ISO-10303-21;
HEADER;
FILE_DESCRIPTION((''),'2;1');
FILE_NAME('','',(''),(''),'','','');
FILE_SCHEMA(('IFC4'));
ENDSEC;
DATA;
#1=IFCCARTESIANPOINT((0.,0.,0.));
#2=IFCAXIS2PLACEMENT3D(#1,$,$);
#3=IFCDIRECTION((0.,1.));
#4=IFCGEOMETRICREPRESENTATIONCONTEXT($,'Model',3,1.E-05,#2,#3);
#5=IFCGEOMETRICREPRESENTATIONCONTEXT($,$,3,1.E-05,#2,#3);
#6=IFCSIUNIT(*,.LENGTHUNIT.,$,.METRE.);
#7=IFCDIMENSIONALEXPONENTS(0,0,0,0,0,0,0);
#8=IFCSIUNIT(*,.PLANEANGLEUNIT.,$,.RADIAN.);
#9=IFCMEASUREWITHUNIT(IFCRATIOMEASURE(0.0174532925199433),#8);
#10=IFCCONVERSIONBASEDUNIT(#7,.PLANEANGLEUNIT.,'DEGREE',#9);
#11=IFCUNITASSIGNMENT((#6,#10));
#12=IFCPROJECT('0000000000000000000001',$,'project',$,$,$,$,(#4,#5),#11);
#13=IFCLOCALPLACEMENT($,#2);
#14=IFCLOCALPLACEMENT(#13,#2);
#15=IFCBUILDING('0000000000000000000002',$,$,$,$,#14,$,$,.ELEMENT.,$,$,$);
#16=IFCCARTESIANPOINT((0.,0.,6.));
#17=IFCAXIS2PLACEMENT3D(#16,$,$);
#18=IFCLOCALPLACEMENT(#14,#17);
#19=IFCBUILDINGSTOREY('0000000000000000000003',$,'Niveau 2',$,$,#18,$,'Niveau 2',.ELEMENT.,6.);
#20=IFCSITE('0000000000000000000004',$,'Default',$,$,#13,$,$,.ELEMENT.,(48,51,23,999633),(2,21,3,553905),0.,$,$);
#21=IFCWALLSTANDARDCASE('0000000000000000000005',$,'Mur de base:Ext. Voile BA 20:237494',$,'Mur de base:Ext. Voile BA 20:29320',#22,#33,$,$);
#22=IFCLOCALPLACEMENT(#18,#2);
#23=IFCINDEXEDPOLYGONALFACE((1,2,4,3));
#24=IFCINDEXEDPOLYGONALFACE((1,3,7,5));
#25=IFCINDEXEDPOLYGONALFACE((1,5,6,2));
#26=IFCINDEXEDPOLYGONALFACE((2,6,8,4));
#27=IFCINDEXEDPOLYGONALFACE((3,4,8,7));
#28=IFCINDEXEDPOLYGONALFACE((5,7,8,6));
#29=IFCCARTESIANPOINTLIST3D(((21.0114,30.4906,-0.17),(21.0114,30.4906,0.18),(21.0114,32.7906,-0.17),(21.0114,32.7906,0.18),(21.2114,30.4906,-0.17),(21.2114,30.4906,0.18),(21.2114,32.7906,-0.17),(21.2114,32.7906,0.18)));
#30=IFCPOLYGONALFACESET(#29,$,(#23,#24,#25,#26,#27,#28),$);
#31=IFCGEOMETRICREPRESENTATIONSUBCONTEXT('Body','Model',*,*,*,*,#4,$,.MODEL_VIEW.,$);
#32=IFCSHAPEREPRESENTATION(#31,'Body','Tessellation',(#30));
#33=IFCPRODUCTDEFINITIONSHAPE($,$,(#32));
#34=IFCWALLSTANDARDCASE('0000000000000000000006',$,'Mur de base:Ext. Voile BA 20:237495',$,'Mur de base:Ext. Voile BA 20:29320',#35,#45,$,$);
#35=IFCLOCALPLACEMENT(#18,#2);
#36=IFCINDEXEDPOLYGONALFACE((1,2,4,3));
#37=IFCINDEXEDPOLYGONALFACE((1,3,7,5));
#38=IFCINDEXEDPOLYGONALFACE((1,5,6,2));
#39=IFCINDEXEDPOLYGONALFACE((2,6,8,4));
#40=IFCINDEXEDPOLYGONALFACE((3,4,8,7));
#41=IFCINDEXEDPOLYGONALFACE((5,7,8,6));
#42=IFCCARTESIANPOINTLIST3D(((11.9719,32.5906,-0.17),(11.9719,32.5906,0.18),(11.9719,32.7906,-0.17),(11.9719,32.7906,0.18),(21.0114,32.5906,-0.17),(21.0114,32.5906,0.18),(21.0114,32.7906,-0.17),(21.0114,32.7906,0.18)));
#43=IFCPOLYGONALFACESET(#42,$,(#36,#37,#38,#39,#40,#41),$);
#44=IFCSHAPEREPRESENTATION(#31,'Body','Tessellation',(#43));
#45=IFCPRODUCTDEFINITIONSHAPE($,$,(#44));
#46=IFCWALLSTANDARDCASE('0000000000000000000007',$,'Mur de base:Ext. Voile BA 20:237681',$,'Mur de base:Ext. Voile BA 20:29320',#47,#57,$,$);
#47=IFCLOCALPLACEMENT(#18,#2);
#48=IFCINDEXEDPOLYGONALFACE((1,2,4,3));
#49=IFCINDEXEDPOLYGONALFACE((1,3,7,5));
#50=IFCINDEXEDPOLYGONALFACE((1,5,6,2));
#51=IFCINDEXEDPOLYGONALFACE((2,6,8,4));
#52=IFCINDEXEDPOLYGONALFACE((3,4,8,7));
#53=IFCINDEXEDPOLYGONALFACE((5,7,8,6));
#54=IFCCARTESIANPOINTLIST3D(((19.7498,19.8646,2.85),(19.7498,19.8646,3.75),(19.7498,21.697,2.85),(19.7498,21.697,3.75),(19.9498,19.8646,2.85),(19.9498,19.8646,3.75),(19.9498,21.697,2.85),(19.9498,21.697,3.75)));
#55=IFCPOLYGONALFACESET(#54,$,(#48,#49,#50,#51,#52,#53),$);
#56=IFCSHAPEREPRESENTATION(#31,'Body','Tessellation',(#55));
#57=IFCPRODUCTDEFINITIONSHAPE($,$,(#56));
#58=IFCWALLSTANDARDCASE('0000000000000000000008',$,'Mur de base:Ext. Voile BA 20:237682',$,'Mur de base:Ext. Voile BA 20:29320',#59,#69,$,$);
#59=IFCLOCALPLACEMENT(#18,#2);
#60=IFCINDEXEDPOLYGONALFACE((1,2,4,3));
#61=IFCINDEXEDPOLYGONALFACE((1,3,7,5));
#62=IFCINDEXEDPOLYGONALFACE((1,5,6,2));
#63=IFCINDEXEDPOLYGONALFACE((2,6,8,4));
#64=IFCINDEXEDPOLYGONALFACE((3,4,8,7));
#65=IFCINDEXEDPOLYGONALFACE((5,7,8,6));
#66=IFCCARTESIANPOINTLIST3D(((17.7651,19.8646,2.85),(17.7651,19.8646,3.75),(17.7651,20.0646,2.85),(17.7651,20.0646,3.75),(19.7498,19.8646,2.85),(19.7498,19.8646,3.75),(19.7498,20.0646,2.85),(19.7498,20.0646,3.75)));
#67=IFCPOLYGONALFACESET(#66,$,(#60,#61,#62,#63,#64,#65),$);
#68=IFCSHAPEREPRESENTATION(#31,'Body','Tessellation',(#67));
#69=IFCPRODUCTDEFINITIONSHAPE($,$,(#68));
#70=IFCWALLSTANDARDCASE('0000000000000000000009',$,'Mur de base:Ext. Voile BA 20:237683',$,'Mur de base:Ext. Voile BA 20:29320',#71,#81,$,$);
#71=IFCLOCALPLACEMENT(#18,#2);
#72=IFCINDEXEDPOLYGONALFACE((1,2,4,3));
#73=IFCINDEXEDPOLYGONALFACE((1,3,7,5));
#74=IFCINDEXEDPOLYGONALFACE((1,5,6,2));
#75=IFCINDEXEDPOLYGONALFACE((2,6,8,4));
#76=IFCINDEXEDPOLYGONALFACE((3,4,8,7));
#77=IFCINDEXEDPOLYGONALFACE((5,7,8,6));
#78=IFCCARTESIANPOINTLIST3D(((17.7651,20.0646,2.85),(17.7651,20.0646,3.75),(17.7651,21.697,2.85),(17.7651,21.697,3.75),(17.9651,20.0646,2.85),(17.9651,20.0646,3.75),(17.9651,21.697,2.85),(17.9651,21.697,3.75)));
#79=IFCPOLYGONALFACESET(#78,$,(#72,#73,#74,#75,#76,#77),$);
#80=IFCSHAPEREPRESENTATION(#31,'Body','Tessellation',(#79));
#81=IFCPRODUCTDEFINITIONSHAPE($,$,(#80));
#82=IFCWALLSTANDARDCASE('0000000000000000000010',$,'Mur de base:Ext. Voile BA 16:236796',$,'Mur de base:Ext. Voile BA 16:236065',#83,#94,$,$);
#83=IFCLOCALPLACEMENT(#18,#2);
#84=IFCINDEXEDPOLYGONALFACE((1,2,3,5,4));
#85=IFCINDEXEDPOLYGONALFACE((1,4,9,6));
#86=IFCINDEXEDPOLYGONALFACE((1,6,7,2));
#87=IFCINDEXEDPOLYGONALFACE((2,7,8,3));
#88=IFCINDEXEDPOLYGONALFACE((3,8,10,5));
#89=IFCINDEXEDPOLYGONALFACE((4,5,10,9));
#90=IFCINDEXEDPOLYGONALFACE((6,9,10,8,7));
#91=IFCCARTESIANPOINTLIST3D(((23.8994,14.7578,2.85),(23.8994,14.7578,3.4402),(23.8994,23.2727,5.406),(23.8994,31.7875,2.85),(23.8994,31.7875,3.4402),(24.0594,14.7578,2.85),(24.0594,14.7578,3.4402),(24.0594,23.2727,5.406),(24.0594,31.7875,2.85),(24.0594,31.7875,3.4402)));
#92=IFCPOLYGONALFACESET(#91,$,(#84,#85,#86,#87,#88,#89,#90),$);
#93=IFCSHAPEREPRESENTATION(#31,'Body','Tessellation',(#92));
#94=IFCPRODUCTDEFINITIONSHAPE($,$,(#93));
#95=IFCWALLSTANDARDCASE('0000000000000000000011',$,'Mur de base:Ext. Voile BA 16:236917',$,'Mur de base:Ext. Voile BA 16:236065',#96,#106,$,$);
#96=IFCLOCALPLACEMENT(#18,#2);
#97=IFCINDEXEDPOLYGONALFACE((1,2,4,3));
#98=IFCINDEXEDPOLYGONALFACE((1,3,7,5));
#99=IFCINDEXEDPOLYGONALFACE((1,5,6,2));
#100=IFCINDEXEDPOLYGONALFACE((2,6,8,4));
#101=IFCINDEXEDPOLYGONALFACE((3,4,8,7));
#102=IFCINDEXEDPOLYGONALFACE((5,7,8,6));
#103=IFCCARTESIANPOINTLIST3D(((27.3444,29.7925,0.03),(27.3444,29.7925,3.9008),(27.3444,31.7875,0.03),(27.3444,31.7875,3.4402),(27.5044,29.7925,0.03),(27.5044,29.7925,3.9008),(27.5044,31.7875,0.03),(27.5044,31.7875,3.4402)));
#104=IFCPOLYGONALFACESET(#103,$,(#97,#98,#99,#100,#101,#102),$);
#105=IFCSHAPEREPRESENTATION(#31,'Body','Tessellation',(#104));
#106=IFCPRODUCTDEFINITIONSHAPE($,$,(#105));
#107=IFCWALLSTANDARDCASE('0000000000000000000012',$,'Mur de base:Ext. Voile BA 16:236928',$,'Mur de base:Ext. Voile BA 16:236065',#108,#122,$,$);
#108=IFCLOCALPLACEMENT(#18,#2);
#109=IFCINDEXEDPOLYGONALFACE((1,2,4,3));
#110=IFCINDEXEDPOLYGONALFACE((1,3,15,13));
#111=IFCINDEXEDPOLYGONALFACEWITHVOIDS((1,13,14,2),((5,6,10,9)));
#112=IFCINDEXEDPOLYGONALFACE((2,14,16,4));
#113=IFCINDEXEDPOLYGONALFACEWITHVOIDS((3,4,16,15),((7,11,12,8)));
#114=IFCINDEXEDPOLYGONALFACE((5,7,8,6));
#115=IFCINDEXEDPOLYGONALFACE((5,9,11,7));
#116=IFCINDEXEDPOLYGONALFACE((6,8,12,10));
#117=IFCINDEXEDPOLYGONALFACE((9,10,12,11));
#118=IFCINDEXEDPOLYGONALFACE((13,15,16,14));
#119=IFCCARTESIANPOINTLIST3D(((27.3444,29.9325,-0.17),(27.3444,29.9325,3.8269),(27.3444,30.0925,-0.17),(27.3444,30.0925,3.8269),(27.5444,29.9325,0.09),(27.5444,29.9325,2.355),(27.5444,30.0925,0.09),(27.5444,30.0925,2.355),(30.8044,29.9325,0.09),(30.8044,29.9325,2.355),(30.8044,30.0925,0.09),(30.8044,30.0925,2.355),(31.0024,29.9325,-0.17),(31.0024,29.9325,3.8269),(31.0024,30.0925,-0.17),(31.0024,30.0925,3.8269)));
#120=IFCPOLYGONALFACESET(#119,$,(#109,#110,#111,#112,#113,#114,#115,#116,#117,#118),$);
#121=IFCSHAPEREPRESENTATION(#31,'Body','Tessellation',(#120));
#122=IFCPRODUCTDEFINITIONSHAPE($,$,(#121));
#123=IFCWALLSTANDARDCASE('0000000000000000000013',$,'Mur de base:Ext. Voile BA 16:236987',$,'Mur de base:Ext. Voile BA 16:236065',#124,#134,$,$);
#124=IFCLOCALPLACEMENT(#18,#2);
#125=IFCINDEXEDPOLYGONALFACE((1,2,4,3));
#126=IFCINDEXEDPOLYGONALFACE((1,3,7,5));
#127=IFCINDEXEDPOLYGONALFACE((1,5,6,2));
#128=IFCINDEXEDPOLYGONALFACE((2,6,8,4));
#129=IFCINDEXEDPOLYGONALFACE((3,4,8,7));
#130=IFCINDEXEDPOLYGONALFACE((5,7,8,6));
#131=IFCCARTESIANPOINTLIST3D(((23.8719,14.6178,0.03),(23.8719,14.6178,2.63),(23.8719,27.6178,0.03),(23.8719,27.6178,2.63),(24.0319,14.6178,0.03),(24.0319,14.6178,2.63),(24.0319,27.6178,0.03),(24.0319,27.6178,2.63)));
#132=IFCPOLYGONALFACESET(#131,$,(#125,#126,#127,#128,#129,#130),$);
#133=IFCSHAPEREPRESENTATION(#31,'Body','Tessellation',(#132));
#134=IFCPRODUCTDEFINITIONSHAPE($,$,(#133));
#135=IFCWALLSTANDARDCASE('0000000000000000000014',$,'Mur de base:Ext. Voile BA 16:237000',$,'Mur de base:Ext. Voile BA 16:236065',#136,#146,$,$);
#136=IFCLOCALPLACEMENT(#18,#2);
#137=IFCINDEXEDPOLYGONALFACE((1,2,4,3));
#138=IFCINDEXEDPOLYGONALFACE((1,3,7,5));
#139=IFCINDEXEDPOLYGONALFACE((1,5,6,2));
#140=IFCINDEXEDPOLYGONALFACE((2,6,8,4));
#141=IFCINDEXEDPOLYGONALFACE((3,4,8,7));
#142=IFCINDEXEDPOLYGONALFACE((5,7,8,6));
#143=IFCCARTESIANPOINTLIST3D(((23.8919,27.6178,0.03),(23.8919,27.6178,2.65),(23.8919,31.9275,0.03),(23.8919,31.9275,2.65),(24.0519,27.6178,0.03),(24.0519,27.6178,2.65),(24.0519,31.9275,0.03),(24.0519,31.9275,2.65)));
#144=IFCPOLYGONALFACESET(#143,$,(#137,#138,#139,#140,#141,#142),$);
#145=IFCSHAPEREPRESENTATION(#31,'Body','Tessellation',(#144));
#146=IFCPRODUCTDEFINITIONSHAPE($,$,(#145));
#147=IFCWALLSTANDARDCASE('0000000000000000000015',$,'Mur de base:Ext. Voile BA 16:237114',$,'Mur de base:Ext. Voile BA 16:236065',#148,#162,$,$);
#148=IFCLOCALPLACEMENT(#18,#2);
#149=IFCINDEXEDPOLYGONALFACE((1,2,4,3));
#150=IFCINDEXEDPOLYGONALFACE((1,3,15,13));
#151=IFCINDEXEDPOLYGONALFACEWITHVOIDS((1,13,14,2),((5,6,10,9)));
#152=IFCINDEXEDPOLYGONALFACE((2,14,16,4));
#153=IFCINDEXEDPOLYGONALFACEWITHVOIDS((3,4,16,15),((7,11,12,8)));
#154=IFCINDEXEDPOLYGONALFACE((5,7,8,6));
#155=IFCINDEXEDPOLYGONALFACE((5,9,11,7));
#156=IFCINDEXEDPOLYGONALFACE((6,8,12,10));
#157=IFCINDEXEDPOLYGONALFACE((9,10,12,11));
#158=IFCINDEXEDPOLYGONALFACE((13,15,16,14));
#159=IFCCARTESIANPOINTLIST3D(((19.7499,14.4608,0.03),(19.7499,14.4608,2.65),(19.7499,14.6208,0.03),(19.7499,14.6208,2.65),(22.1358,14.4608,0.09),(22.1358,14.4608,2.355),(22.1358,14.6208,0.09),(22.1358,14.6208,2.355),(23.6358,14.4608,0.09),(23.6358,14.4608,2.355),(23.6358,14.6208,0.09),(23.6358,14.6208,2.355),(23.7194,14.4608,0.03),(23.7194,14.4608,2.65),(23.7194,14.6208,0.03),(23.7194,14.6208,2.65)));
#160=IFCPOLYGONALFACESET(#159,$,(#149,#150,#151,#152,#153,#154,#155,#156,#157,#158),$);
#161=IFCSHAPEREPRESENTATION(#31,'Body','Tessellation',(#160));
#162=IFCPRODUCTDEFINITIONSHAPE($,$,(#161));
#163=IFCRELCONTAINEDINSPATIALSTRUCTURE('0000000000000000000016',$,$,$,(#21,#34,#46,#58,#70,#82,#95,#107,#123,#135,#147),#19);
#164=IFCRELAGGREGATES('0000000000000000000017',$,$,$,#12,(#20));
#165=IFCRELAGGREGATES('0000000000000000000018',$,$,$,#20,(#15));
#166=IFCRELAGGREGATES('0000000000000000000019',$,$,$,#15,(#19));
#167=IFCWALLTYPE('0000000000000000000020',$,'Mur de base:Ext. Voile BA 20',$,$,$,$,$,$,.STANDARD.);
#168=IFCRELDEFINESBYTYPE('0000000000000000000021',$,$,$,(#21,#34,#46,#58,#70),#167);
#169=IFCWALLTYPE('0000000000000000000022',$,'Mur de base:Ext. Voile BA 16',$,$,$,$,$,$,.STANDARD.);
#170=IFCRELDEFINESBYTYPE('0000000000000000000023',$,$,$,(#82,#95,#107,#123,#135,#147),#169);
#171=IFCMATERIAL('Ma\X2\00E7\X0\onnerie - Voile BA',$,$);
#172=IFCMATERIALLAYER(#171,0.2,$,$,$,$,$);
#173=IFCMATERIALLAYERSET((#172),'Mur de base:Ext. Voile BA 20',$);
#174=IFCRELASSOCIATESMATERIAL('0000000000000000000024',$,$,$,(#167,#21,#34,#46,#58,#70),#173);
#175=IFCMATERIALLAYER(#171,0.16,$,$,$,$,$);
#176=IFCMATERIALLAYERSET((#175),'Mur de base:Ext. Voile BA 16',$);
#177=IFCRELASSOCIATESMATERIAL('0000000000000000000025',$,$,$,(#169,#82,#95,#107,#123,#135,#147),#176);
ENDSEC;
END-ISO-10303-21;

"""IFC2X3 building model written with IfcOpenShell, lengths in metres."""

from ifc_helpers import new_model, entity, si_unit, converted_unit, direction, frame, frame_2d, origin, origin_2d_with_axis, place, context, subcontext, project, spatial, rectangle, extrude, clip, halfspace, material, layer, layer_set, layer_usage, type_object, element, save


model = new_model("IFC2X3")

# Units and contexts
model_context = context("Model", 3, precision=1e-05, world=origin(), true_north=direction((0.0, 1.0)))
context_of_model = context(None, 3, precision=1e-05, world=origin(), true_north=direction((0.0, 1.0)))
body_context = subcontext(model_context, "Body", "Model", "MODEL_VIEW")
ifc_project = project(units=[si_unit("LENGTHUNIT", "METRE"), converted_unit("PLANEANGLEUNIT", "DEGREE", entity("IfcRatioMeasure", 0.0174532925199433), si_unit("PLANEANGLEUNIT", "RADIAN"), dimensions=[0, 0, 0, 0, 0, 0, 0])], contexts=[model_context, context_of_model])

# Site, building, storey
site_placement = place(None, origin())
site = spatial("IfcSite", under=ifc_project, at=site_placement, Name="Default", CompositionType="ELEMENT", RefLatitude=(48, 51, 23, 999633), RefLongitude=(2, 21, 3, 553905), RefElevation=0.0)
building_placement = place(site_placement, origin())
building = spatial("IfcBuilding", under=site, at=building_placement, CompositionType="ELEMENT")
storey_placement = place(building_placement, frame((0.0, 0.0, 6.0)))
storey = spatial("IfcBuildingStorey", under=building, at=storey_placement, Name="Niveau 2", LongName="Niveau 2", CompositionType="ELEMENT", Elevation=6.0)

# Shared definitions
ifc_material = material(Name="Maçonnerie - Voile BA")
ifc_layer_1 = layer(ifc_material, 0.2)
ifc_layer_set_1 = layer_set([ifc_layer_1], Name="Mur de base:Ext. Voile BA 20")
wall_type_1 = type_object("IfcWallType", Name="Mur de base:Ext. Voile BA 20", PredefinedType="STANDARD", material=ifc_layer_set_1)

# Walls
ifc_layer_usage_1 = layer_usage(ifc_layer_set_1, "AXIS2", "POSITIVE", -0.1)
wall_1_placement = place(storey_placement, frame((21.1114, 30.4906, -0.17), z_axis=(0.0, 0.0, 1.0), x_axis=(0.0, 1.0, 0.0)))
element("IfcWallStandardCase", 1, at=wall_1_placement, inside=storey, type_object=wall_type_1, material=ifc_layer_usage_1, Name="Mur de base:Ext. Voile BA 20:237494", ObjectType="Mur de base:Ext. Voile BA 20:29320", context=body_context, shape_type="SweptSolid", body=[
    extrude(rectangle(XDim=2.3, YDim=0.2, at=frame_2d((1.15, 0.0), x_axis=(-1.0, 0.0))), origin(), (0.0, 0.0, 1.0), 0.35),
])
ifc_layer_usage_2 = layer_usage(ifc_layer_set_1, "AXIS2", "POSITIVE", -0.1)
wall_2_placement = place(storey_placement, frame((21.0114, 32.6906, -0.17), z_axis=(0.0, 0.0, 1.0), x_axis=(-1.0, 0.0, 0.0)))
element("IfcWallStandardCase", 2, at=wall_2_placement, inside=storey, type_object=wall_type_1, material=ifc_layer_usage_2, Name="Mur de base:Ext. Voile BA 20:237495", ObjectType="Mur de base:Ext. Voile BA 20:29320", context=body_context, shape_type="SweptSolid", body=[
    extrude(rectangle(XDim=9.0395, YDim=0.2, at=frame_2d((4.5197, 0.0), x_axis=(-1.0, 0.0))), origin(), (0.0, 0.0, 1.0), 0.35),
])
ifc_layer_usage_3 = layer_usage(ifc_layer_set_1, "AXIS2", "NEGATIVE", 0.1)
wall_3_placement = place(storey_placement, frame((19.8498, 21.697, 2.85), z_axis=(0.0, 0.0, 1.0), x_axis=(0.0, -1.0, 0.0)))
element("IfcWallStandardCase", 3, at=wall_3_placement, inside=storey, type_object=wall_type_1, material=ifc_layer_usage_3, Name="Mur de base:Ext. Voile BA 20:237681", ObjectType="Mur de base:Ext. Voile BA 20:29320", context=body_context, shape_type="SweptSolid", body=[
    extrude(rectangle(XDim=1.8324, YDim=0.2, at=frame_2d((0.9162, 0.0), x_axis=(-1.0, 0.0))), origin(), (0.0, 0.0, 1.0), 0.9),
])
ifc_layer_usage_4 = layer_usage(ifc_layer_set_1, "AXIS2", "NEGATIVE", 0.1)
wall_4_placement = place(storey_placement, frame((19.7498, 19.9646, 2.85), z_axis=(0.0, 0.0, 1.0), x_axis=(-1.0, 0.0, 0.0)))
element("IfcWallStandardCase", 4, at=wall_4_placement, inside=storey, type_object=wall_type_1, material=ifc_layer_usage_4, Name="Mur de base:Ext. Voile BA 20:237682", ObjectType="Mur de base:Ext. Voile BA 20:29320", context=body_context, shape_type="SweptSolid", body=[
    extrude(rectangle(XDim=1.9848, YDim=0.2, at=frame_2d((0.9924, 0.0), x_axis=(-1.0, 0.0))), origin(), (0.0, 0.0, 1.0), 0.9),
])
ifc_layer_usage_5 = layer_usage(ifc_layer_set_1, "AXIS2", "NEGATIVE", 0.1)
wall_5_placement = place(storey_placement, frame((17.8651, 20.0646, 2.85), z_axis=(0.0, 0.0, 1.0), x_axis=(0.0, 1.0, 0.0)))
element("IfcWallStandardCase", 5, at=wall_5_placement, inside=storey, type_object=wall_type_1, material=ifc_layer_usage_5, Name="Mur de base:Ext. Voile BA 20:237683", ObjectType="Mur de base:Ext. Voile BA 20:29320", context=body_context, shape_type="SweptSolid", body=[
    extrude(rectangle(XDim=1.6324, YDim=0.2, at=frame_2d((0.8162, 0.0), x_axis=(-1.0, 0.0))), origin(), (0.0, 0.0, 1.0), 0.9),
])
ifc_layer_2 = layer(ifc_material, 0.16)
ifc_layer_set_2 = layer_set([ifc_layer_2], Name="Mur de base:Ext. Voile BA 16")
ifc_layer_usage_6 = layer_usage(ifc_layer_set_2, "AXIS2", "NEGATIVE", 0.08)
wall_type_2 = type_object("IfcWallType", Name="Mur de base:Ext. Voile BA 16", PredefinedType="STANDARD", material=ifc_layer_set_2)
wall_6_placement = place(storey_placement, frame((23.9794, 14.7578, 2.85), z_axis=(0.0, 0.0, 1.0), x_axis=(0.0, 1.0, 0.0)))
element("IfcWallStandardCase", 6, at=wall_6_placement, inside=storey, type_object=wall_type_2, material=ifc_layer_usage_6, Name="Mur de base:Ext. Voile BA 16:236796", ObjectType="Mur de base:Ext. Voile BA 16:236065", context=body_context, shape_type="Clipping", body=[
    clip(clip(extrude(rectangle(XDim=17.0297, YDim=0.16, at=frame_2d((8.5148, 0.0), x_axis=(-1.0, 0.0))), origin(), (0.0, 0.0, 1.0), 2.556), halfspace(frame((0.0, -0.08, 0.5902), z_axis=(-0.224951, 0.0, 0.97437), x_axis=(0.0, 1.0, 0.0)), False)), halfspace(frame((8.5148, -0.08, 2.556), z_axis=(0.224951, 0.0, 0.97437), x_axis=(0.0, 1.0, 0.0)), False)),
])

# Wall
ifc_layer_usage_7 = layer_usage(ifc_layer_set_2, "AXIS2", "NEGATIVE", 0.08)
wall_7_placement = place(storey_placement, frame((27.4244, 31.7875, 0.03), z_axis=(0.0, 0.0, 1.0), x_axis=(0.0, -1.0, 0.0)))
element("IfcWallStandardCase", 7, at=wall_7_placement, inside=storey, type_object=wall_type_2, material=ifc_layer_usage_7, Name="Mur de base:Ext. Voile BA 16:236917", ObjectType="Mur de base:Ext. Voile BA 16:236065", context=body_context, shape_type="Clipping", body=[
    clip(extrude(rectangle(XDim=1.995, YDim=0.16, at=frame_2d((0.9975, 0.0), x_axis=(-1.0, 0.0))), origin(), (0.0, 0.0, 1.0), 3.8708), halfspace(frame((0.0, -0.08, 3.4102), z_axis=(-0.224951, 0.0, 0.97437), x_axis=(0.0, 1.0, 0.0)), False)),
])

# Wall, opening
ifc_layer_usage_8 = layer_usage(ifc_layer_set_2, "AXIS2", "NEGATIVE", 0.08)
wall_8_placement = place(storey_placement, frame((27.3444, 30.0125, -0.17)))
wall_8 = element("IfcWallStandardCase", 8, at=wall_8_placement, inside=storey, type_object=wall_type_2, material=ifc_layer_usage_8, Name="Mur de base:Ext. Voile BA 16:236928", ObjectType="Mur de base:Ext. Voile BA 16:236065", context=body_context, shape_type="SweptSolid", body=[
    extrude(rectangle(XDim=3.658, YDim=0.16, at=frame_2d((1.829, 0.0), x_axis=(-1.0, 0.0))), origin(), (0.0, 0.0, 1.0), 3.9969),
])
opening_1_placement = place(wall_8_placement, origin())
element("IfcOpeningElement", 9, at=opening_1_placement, cuts=wall_8, ObjectType="Opening", context=body_context, shape_type="SweptSolid", body=[
    extrude(rectangle(XDim=2.265, YDim=3.26, at=origin_2d_with_axis()), frame((1.83, -0.08, 1.3925), z_axis=(0.0, 1.0, 0.0), x_axis=(0.0, 0.0, -1.0)), (0.0, 0.0, 1.0), 0.16),
])

# Walls
ifc_layer_usage_9 = layer_usage(ifc_layer_set_2, "AXIS2", "NEGATIVE", 0.08)
wall_9_placement = place(storey_placement, frame((23.9519, 27.6178, 0.03), z_axis=(0.0, 0.0, 1.0), x_axis=(0.0, -1.0, 0.0)))
element("IfcWallStandardCase", 10, at=wall_9_placement, inside=storey, type_object=wall_type_2, material=ifc_layer_usage_9, Name="Mur de base:Ext. Voile BA 16:236987", ObjectType="Mur de base:Ext. Voile BA 16:236065", context=body_context, shape_type="SweptSolid", body=[
    extrude(rectangle(XDim=13.0, YDim=0.16, at=frame_2d((6.5, 0.0), x_axis=(-1.0, 0.0))), origin(), (0.0, 0.0, 1.0), 2.6),
])
ifc_layer_usage_10 = layer_usage(ifc_layer_set_2, "AXIS2", "NEGATIVE", 0.08)
wall_10_placement = place(storey_placement, frame((23.9719, 27.6178, 0.03), z_axis=(0.0, 0.0, 1.0), x_axis=(0.0, 1.0, 0.0)))
element("IfcWallStandardCase", 11, at=wall_10_placement, inside=storey, type_object=wall_type_2, material=ifc_layer_usage_10, Name="Mur de base:Ext. Voile BA 16:237000", ObjectType="Mur de base:Ext. Voile BA 16:236065", context=body_context, shape_type="SweptSolid", body=[
    extrude(rectangle(XDim=4.3097, YDim=0.16, at=frame_2d((2.1548, 0.0), x_axis=(-1.0, 0.0))), origin(), (0.0, 0.0, 1.0), 2.62),
])

# Wall, opening
ifc_layer_usage_11 = layer_usage(ifc_layer_set_2, "AXIS2", "NEGATIVE", 0.08)
wall_11_placement = place(storey_placement, frame((23.7194, 14.5408, 0.03), z_axis=(0.0, 0.0, 1.0), x_axis=(-1.0, 0.0, 0.0)))
wall_11 = element("IfcWallStandardCase", 12, at=wall_11_placement, inside=storey, type_object=wall_type_2, material=ifc_layer_usage_11, Name="Mur de base:Ext. Voile BA 16:237114", ObjectType="Mur de base:Ext. Voile BA 16:236065", context=body_context, shape_type="SweptSolid", body=[
    extrude(rectangle(XDim=3.9695, YDim=0.16, at=frame_2d((1.9848, 0.0), x_axis=(-1.0, 0.0))), origin(), (0.0, 0.0, 1.0), 2.62),
])
opening_2_placement = place(wall_11_placement, origin())
element("IfcOpeningElement", 13, at=opening_2_placement, cuts=wall_11, ObjectType="Opening", context=body_context, shape_type="SweptSolid", body=[
    extrude(rectangle(XDim=2.265, YDim=1.5, at=origin_2d_with_axis()), frame((0.8336, -0.08, 1.1925), z_axis=(0.0, 1.0, 0.0), x_axis=(0.0, 0.0, -1.0)), (0.0, 0.0, 1.0), 0.16),
])

save(model, "model.ifc")
